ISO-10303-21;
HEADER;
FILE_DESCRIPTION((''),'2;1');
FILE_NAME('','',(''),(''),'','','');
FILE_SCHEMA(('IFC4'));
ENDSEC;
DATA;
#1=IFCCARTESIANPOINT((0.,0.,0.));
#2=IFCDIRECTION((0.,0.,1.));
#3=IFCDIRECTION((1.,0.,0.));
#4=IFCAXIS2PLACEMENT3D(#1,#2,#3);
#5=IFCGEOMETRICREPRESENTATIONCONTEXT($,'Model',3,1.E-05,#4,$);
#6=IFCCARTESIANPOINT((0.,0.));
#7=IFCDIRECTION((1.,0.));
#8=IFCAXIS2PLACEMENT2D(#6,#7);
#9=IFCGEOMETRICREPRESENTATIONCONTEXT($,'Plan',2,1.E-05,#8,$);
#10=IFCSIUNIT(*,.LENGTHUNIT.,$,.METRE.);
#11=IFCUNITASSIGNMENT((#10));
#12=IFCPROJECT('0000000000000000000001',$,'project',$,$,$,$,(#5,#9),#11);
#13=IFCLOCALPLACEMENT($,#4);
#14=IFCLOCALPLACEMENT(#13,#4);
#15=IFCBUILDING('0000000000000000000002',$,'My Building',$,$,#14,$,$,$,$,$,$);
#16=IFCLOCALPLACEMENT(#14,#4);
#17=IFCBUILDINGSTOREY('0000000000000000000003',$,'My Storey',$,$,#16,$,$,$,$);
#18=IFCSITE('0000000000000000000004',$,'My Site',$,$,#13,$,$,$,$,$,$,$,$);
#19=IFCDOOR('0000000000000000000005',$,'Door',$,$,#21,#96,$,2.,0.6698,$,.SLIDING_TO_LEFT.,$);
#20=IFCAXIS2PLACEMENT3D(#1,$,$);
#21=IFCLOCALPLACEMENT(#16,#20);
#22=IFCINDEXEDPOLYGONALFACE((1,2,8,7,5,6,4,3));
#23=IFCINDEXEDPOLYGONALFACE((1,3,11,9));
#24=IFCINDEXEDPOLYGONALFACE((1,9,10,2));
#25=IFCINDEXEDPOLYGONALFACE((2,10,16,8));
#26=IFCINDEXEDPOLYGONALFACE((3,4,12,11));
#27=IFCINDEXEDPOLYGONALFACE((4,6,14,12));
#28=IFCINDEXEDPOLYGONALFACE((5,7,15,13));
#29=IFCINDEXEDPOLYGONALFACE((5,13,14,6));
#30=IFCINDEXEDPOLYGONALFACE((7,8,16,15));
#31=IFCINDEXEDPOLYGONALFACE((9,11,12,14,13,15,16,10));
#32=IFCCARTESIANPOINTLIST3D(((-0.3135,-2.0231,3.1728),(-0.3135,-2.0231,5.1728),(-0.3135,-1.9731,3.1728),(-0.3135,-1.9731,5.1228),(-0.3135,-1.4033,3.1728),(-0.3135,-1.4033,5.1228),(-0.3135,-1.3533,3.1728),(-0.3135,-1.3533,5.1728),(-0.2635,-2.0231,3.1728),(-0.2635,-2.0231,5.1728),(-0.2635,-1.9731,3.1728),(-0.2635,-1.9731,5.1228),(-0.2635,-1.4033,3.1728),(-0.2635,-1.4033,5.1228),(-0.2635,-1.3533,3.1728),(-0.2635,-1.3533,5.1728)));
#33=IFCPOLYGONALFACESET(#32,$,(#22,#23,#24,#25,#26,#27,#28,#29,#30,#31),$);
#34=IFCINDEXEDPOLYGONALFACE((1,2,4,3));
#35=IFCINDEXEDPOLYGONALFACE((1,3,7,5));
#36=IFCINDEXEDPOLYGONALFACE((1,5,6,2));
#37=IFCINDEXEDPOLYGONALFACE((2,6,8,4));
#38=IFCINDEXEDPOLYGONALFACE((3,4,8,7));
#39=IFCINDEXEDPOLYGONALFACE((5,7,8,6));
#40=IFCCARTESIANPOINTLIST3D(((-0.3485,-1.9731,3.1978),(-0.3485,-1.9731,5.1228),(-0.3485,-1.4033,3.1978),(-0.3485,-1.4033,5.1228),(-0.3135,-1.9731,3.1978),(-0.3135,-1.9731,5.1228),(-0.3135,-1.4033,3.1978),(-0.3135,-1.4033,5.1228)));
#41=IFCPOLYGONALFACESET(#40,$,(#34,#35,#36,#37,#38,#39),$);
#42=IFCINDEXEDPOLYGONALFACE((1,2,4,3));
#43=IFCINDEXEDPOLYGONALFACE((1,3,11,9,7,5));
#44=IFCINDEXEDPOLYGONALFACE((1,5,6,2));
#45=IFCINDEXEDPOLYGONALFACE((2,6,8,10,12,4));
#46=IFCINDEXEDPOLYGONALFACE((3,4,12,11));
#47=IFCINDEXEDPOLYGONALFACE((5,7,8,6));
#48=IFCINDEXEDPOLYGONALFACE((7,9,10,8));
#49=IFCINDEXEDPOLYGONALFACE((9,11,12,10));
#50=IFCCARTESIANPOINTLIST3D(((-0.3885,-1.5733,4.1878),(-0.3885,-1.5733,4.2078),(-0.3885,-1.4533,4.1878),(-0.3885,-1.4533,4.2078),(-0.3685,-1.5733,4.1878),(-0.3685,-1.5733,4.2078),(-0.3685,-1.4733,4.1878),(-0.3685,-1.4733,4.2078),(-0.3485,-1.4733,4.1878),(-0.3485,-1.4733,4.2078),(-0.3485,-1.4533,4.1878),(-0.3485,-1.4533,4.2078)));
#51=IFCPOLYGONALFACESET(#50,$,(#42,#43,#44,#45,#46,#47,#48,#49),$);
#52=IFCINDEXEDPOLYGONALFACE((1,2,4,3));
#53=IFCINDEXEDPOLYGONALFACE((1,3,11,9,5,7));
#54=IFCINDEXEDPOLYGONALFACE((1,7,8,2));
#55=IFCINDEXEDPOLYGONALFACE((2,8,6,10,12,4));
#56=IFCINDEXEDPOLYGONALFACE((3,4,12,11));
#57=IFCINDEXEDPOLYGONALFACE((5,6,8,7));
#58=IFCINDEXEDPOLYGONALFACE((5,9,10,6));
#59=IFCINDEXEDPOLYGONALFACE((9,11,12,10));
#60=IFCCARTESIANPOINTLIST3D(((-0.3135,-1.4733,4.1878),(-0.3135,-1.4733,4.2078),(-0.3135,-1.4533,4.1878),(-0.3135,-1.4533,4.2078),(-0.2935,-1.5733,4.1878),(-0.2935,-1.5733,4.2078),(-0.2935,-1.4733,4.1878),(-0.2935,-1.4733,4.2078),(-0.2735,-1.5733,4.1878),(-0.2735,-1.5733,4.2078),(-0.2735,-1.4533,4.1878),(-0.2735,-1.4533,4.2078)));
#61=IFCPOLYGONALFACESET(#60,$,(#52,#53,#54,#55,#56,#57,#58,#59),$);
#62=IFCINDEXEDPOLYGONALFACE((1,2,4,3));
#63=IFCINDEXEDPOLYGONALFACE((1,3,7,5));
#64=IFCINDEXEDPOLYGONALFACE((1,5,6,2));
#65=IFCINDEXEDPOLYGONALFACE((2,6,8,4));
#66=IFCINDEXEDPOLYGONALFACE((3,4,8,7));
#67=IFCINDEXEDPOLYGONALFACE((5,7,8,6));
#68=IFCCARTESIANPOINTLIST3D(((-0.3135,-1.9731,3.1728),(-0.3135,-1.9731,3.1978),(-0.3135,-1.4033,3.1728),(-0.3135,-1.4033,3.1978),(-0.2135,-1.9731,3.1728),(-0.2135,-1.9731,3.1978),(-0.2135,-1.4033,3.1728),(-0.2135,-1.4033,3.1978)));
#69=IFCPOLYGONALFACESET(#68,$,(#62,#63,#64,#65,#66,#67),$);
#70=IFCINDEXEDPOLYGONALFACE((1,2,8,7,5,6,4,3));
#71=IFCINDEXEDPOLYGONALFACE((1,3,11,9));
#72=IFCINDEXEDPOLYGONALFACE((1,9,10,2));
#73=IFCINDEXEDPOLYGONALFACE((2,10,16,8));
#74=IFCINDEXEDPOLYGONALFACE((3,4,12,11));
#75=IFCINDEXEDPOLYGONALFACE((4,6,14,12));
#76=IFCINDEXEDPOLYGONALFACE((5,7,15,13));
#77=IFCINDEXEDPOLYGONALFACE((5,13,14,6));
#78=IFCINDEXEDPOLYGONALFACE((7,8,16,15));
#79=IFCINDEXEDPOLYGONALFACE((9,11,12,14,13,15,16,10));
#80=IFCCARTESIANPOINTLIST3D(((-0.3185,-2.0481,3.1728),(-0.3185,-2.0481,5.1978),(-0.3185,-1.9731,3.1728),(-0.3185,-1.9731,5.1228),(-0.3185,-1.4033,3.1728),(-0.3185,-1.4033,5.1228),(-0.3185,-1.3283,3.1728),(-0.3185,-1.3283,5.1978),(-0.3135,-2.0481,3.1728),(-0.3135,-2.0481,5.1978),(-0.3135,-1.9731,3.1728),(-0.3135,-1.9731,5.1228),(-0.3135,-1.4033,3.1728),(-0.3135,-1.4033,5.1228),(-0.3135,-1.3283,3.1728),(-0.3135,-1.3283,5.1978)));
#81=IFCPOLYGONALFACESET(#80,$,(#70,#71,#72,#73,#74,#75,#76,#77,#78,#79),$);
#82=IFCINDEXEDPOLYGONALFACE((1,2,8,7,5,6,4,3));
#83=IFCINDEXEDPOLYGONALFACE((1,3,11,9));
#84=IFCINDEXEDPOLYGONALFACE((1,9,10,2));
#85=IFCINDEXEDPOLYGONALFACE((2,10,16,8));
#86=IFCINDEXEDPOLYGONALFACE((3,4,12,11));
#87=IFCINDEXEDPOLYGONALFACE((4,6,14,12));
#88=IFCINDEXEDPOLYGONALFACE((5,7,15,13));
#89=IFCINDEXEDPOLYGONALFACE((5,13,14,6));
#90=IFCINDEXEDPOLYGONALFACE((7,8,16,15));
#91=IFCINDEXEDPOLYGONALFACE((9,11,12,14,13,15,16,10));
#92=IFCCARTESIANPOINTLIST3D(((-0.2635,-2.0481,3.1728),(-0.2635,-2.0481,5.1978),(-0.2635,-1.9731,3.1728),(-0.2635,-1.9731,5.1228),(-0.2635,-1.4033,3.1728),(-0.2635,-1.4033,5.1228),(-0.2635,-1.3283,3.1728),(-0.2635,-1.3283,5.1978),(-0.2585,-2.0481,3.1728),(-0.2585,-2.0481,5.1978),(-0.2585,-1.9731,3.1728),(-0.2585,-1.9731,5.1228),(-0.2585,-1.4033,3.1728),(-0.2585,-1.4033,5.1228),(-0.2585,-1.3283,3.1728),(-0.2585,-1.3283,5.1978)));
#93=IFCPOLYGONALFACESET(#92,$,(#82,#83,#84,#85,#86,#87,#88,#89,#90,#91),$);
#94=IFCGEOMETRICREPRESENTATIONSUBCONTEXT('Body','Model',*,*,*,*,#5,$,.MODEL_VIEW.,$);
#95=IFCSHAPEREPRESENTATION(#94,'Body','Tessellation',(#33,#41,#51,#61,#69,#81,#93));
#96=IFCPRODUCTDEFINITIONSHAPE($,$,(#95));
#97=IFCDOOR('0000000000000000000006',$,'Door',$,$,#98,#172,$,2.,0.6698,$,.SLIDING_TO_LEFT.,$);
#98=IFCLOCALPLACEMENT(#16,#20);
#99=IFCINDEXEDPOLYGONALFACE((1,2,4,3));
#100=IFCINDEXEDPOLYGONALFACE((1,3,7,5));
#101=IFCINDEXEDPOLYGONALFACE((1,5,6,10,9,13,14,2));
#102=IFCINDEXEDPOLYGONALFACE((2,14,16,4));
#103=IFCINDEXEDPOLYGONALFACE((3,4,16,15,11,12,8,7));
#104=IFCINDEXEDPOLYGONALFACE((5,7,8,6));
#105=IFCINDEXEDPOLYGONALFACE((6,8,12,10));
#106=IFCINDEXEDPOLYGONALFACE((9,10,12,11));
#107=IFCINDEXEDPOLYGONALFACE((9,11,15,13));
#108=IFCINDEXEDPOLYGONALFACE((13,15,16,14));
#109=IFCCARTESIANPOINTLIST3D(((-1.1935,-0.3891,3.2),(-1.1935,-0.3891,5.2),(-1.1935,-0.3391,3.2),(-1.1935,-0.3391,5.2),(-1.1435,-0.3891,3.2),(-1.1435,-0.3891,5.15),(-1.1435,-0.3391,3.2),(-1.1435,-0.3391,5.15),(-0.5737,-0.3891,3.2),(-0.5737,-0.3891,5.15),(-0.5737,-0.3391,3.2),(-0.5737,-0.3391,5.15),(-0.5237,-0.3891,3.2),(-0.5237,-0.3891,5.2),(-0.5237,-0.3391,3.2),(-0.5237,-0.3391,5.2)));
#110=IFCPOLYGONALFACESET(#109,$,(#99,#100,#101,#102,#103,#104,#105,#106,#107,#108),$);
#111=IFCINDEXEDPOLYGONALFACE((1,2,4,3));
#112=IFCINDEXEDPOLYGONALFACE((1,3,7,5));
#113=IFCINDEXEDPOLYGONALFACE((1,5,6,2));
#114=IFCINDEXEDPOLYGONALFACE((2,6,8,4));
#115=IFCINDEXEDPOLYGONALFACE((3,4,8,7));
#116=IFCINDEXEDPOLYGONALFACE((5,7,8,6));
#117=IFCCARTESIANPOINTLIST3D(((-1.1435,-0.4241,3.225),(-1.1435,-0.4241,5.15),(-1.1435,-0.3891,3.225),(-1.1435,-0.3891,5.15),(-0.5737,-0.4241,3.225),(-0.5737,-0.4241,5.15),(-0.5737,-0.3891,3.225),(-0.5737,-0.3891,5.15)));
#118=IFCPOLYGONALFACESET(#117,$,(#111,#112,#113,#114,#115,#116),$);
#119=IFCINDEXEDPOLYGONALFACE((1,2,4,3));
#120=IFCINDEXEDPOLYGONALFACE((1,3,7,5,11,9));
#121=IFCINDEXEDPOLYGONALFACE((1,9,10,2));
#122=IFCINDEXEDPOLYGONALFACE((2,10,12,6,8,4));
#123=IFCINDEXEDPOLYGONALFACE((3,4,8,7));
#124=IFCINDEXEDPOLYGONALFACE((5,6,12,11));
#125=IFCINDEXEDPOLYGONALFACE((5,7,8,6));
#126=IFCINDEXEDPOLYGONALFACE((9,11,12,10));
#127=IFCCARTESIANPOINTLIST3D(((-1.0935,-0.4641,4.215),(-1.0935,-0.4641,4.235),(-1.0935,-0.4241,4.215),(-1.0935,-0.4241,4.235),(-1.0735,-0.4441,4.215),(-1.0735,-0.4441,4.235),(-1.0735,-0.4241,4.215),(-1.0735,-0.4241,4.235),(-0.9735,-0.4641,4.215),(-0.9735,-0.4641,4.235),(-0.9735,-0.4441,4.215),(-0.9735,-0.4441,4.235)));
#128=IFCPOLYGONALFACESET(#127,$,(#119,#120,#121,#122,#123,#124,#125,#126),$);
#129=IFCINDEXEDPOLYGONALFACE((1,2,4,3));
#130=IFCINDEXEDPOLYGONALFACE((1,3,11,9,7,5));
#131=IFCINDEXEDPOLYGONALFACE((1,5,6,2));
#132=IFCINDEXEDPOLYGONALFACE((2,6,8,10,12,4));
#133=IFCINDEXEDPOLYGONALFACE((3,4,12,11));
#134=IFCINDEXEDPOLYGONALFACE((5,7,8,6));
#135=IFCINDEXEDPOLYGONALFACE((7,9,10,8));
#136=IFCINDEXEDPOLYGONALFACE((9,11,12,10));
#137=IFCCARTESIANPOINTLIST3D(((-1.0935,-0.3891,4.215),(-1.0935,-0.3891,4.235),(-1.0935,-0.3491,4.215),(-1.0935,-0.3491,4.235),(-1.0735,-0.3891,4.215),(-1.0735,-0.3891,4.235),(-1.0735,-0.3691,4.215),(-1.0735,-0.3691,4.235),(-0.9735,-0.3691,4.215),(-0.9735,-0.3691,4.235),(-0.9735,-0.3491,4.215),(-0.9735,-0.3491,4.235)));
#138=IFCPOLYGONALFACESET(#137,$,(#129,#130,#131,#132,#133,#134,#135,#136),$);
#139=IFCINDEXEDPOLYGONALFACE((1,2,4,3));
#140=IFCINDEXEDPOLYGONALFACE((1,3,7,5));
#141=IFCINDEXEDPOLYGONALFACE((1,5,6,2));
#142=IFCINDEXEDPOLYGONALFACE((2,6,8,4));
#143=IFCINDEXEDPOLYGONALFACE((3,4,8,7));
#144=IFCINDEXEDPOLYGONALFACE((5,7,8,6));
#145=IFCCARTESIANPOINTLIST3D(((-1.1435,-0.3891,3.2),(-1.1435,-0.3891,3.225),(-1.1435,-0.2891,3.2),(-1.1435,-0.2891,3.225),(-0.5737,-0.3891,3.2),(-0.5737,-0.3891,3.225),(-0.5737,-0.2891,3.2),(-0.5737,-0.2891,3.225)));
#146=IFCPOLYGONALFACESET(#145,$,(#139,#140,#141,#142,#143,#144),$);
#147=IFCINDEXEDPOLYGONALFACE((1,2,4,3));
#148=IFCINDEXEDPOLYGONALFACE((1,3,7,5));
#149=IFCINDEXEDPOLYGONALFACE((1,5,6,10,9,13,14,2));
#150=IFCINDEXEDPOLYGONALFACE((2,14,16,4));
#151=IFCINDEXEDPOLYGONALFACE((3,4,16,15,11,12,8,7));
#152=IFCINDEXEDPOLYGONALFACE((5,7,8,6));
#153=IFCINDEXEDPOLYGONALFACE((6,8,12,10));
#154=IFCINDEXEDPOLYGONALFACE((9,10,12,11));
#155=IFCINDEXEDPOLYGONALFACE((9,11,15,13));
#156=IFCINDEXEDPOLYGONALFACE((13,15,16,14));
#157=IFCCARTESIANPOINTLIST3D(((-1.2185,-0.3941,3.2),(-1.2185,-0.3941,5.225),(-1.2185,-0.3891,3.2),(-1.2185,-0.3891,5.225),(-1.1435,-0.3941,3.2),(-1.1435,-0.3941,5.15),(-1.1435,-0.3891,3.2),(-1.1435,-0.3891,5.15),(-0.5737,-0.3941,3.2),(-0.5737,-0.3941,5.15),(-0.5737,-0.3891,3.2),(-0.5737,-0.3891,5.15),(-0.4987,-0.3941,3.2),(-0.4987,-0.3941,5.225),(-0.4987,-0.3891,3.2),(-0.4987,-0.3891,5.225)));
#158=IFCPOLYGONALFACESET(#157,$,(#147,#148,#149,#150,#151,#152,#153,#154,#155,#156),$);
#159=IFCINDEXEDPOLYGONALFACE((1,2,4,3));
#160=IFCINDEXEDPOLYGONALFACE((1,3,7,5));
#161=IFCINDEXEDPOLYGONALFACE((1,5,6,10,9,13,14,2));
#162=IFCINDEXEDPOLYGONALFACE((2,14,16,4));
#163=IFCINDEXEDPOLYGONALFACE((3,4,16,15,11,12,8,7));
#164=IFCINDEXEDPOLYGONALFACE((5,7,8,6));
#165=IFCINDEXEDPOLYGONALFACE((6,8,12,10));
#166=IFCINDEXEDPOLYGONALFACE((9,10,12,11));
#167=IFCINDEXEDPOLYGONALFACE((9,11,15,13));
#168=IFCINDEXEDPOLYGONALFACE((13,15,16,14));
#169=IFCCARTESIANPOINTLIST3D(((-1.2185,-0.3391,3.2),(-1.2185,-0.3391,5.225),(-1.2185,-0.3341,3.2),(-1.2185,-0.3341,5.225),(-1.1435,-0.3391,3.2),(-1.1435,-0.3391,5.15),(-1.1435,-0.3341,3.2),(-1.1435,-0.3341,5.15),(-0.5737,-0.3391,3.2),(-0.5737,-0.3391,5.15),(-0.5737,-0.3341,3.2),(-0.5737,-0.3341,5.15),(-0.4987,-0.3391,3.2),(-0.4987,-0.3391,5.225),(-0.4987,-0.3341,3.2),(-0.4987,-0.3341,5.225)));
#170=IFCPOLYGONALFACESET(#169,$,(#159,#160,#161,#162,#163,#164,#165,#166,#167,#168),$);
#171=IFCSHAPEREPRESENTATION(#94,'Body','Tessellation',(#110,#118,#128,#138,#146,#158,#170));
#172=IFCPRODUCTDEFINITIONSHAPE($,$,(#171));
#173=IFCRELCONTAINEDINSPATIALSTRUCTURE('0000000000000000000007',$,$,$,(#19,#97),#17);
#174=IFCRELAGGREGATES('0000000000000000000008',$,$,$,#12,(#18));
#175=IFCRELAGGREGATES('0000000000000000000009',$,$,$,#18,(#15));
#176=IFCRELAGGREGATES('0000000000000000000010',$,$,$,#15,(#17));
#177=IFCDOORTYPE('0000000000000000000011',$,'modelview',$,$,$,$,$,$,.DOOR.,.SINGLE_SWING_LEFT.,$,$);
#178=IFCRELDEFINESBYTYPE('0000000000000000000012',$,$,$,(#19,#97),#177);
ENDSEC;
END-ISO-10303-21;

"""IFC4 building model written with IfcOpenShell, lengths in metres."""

from ifc_helpers import new_model, entity, si_unit, frame, origin_with_axes, origin_2d_with_axis, place, context, subcontext, project, spatial, line, indexed_curve, outline, extrude, shape, source, transform, mapped, type_object, type_shapes, element, save


model = new_model("IFC4")

# Units and contexts
model_context = context("Model", 3, precision=1e-05, world=origin_with_axes())
plan_context = context("Plan", 2, precision=1e-05, world=origin_2d_with_axis())
body_context_1 = subcontext(model_context, "Body", "Model", "MODEL_VIEW")
body_context_2 = subcontext(plan_context, "Body", "Plan", "PLAN_VIEW")
ifc_project = project(units=[si_unit("LENGTHUNIT", "METRE")], contexts=[model_context, plan_context])

# Site, building, storey
site_placement = place(None, origin_with_axes())
site = spatial("IfcSite", under=ifc_project, at=site_placement, Name="My Site")
building_placement = place(site_placement, origin_with_axes())
building = spatial("IfcBuilding", under=site, at=building_placement, Name="My Building")
storey_placement = place(building_placement, origin_with_axes())
storey = spatial("IfcBuildingStorey", under=building, at=storey_placement, Name="My Storey")

# Shared definitions
door_type_1 = type_object("IfcDoorType", Name="modelview", OperationType="SINGLE_SWING_LEFT", PredefinedType="DOOR")
shared_shape_1 = source(origin_with_axes(), body_context_1, "Body", "SweptSolid", [
    extrude(outline(indexed_curve([(0.0, 0.0), (0.0, 2.0), (0.6698, 2.0), (0.6698, 0.0), (0.6198, 0.0), (0.6198, 1.95), (0.05, 1.95), (0.05, 0.0)], segments=[line(1, 2, 3, 4, 5, 6, 7, 8, 1)])), frame((0.0, 0.0, 0.0), z_axis=(0.0, -1.0, 0.0), x_axis=(1.0, 0.0, 0.0)), (0.0, 0.0, -1.0), 0.05),
    extrude(outline(indexed_curve([(0.0, 0.0), (0.5698, 0.0), (0.5698, 0.035), (0.0, 0.035)], segments=[line(1, 2, 3, 4, 1)])), frame((0.05, -0.035, 0.025), z_axis=(0.0, 0.0, 1.0), x_axis=(1.0, 0.0, 0.0)), (0.0, 0.0, 1.0), 1.925),
    extrude(outline(indexed_curve([(0.0, 0.0), (0.0, -0.04), (0.12, -0.04), (0.12, -0.02), (0.02, -0.02), (0.02, 0.0)], segments=[line(1, 2, 3, 4, 5, 6, 1)])), frame((0.1, -0.035, 1.015), z_axis=(0.0, 0.0, 1.0), x_axis=(1.0, 0.0, 0.0)), (0.0, 0.0, 1.0), 0.02),
    extrude(outline(indexed_curve([(0.0, 0.0), (0.0, 0.04), (0.12, 0.04), (0.12, 0.02), (0.02, 0.02), (0.02, 0.0)], segments=[line(1, 2, 3, 4, 5, 6, 1)])), frame((0.1, 0.0, 1.015), z_axis=(0.0, 0.0, 1.0), x_axis=(1.0, 0.0, 0.0)), (0.0, 0.0, 1.0), 0.02),
    extrude(outline(indexed_curve([(0.0, 0.0), (0.5698, 0.0), (0.5698, 0.1), (0.0, 0.1)], segments=[line(1, 2, 3, 4, 1)])), frame((0.05, 0.0, 0.0), z_axis=(0.0, 0.0, 1.0), x_axis=(1.0, 0.0, 0.0)), (0.0, 0.0, 1.0), 0.025),
    extrude(outline(indexed_curve([(0.0, 0.0), (0.0, 2.025), (0.7198, 2.025), (0.7198, 0.0), (0.6448, 0.0), (0.6448, 1.95), (0.075, 1.95), (0.075, 0.0)], segments=[line(1, 2, 3, 4, 5, 6, 7, 8, 1)])), frame((-0.025, -0.005, 0.0), z_axis=(0.0, -1.0, 0.0), x_axis=(1.0, 0.0, 0.0)), (0.0, 0.0, -1.0), 0.005),
    extrude(outline(indexed_curve([(0.0, 0.0), (0.0, 2.025), (0.7198, 2.025), (0.7198, 0.0), (0.6448, 0.0), (0.6448, 1.95), (0.075, 1.95), (0.075, 0.0)], segments=[line(1, 2, 3, 4, 5, 6, 7, 8, 1)])), frame((-0.025, 0.05, 0.0), z_axis=(0.0, -1.0, 0.0), x_axis=(1.0, 0.0, 0.0)), (0.0, 0.0, -1.0), 0.005),
])
shared_shape_2 = source(origin_with_axes(), body_context_2, "Body", "Curve2D", [
    entity("IfcIndexedPolyCurve", entity("IfcCartesianPointList2D", [[0.0, 0.0], [0.05, 0.0], [0.05, 0.05], [0.0, 0.05]]), [entity("IfcLineIndex", [1, 2, 3, 4, 1])]),
    entity("IfcIndexedPolyCurve", entity("IfcCartesianPointList2D", [[0.6698, 0.0], [0.6198, 0.0], [0.6198, 0.05], [0.6698, 0.05]]), [entity("IfcLineIndex", [1, 2, 3, 4, 1])]),
    entity("IfcIndexedPolyCurve", entity("IfcCartesianPointList2D", [[0.9047, -0.035], [0.3349, -0.035], [0.3349, 0.0], [0.9047, 0.0]]), [entity("IfcLineIndex", [1, 2, 3, 4, 1])]),
])
type_shapes(door_type_1, [shared_shape_1, shared_shape_2])

# Doors
for number, where, z_axis, x_axis, name in (
    (1, (-0.3135, -1.3533, 3.1728), (0.0, 0.0, 1.0), (0.0, -1.0, 0.0), "Door"),
    (2, (-1.1935, -0.3891, 3.2), (0.0, 0.0, 1.0), (1.0, 0.0, 0.0), "Door"),
):
    element("IfcDoor", number, at=place(storey_placement, frame(where, z_axis=z_axis, x_axis=x_axis)), inside=storey, type_object=door_type_1, Name=name, OperationType="SLIDING_TO_LEFT", OverallHeight=2.0, OverallWidth=0.6698, shapes=[
        shape(body_context_1, "Body", "MappedRepresentation", [mapped(shared_shape_1, transform((0.0, 0.0, 0.0), x_axis=(1.0, 0.0, 0.0), y_axis=(0.0, 1.0, 0.0), z_axis=(0.0, 0.0, 1.0), scale=1.0))]),
        shape(body_context_2, "Body", "MappedRepresentation", [mapped(shared_shape_2, transform((0.0, 0.0, 0.0), x_axis=(1.0, 0.0, 0.0), y_axis=(0.0, 1.0, 0.0), z_axis=(0.0, 0.0, 1.0), scale=1.0))]),
    ])

save(model, "model.ifc")
